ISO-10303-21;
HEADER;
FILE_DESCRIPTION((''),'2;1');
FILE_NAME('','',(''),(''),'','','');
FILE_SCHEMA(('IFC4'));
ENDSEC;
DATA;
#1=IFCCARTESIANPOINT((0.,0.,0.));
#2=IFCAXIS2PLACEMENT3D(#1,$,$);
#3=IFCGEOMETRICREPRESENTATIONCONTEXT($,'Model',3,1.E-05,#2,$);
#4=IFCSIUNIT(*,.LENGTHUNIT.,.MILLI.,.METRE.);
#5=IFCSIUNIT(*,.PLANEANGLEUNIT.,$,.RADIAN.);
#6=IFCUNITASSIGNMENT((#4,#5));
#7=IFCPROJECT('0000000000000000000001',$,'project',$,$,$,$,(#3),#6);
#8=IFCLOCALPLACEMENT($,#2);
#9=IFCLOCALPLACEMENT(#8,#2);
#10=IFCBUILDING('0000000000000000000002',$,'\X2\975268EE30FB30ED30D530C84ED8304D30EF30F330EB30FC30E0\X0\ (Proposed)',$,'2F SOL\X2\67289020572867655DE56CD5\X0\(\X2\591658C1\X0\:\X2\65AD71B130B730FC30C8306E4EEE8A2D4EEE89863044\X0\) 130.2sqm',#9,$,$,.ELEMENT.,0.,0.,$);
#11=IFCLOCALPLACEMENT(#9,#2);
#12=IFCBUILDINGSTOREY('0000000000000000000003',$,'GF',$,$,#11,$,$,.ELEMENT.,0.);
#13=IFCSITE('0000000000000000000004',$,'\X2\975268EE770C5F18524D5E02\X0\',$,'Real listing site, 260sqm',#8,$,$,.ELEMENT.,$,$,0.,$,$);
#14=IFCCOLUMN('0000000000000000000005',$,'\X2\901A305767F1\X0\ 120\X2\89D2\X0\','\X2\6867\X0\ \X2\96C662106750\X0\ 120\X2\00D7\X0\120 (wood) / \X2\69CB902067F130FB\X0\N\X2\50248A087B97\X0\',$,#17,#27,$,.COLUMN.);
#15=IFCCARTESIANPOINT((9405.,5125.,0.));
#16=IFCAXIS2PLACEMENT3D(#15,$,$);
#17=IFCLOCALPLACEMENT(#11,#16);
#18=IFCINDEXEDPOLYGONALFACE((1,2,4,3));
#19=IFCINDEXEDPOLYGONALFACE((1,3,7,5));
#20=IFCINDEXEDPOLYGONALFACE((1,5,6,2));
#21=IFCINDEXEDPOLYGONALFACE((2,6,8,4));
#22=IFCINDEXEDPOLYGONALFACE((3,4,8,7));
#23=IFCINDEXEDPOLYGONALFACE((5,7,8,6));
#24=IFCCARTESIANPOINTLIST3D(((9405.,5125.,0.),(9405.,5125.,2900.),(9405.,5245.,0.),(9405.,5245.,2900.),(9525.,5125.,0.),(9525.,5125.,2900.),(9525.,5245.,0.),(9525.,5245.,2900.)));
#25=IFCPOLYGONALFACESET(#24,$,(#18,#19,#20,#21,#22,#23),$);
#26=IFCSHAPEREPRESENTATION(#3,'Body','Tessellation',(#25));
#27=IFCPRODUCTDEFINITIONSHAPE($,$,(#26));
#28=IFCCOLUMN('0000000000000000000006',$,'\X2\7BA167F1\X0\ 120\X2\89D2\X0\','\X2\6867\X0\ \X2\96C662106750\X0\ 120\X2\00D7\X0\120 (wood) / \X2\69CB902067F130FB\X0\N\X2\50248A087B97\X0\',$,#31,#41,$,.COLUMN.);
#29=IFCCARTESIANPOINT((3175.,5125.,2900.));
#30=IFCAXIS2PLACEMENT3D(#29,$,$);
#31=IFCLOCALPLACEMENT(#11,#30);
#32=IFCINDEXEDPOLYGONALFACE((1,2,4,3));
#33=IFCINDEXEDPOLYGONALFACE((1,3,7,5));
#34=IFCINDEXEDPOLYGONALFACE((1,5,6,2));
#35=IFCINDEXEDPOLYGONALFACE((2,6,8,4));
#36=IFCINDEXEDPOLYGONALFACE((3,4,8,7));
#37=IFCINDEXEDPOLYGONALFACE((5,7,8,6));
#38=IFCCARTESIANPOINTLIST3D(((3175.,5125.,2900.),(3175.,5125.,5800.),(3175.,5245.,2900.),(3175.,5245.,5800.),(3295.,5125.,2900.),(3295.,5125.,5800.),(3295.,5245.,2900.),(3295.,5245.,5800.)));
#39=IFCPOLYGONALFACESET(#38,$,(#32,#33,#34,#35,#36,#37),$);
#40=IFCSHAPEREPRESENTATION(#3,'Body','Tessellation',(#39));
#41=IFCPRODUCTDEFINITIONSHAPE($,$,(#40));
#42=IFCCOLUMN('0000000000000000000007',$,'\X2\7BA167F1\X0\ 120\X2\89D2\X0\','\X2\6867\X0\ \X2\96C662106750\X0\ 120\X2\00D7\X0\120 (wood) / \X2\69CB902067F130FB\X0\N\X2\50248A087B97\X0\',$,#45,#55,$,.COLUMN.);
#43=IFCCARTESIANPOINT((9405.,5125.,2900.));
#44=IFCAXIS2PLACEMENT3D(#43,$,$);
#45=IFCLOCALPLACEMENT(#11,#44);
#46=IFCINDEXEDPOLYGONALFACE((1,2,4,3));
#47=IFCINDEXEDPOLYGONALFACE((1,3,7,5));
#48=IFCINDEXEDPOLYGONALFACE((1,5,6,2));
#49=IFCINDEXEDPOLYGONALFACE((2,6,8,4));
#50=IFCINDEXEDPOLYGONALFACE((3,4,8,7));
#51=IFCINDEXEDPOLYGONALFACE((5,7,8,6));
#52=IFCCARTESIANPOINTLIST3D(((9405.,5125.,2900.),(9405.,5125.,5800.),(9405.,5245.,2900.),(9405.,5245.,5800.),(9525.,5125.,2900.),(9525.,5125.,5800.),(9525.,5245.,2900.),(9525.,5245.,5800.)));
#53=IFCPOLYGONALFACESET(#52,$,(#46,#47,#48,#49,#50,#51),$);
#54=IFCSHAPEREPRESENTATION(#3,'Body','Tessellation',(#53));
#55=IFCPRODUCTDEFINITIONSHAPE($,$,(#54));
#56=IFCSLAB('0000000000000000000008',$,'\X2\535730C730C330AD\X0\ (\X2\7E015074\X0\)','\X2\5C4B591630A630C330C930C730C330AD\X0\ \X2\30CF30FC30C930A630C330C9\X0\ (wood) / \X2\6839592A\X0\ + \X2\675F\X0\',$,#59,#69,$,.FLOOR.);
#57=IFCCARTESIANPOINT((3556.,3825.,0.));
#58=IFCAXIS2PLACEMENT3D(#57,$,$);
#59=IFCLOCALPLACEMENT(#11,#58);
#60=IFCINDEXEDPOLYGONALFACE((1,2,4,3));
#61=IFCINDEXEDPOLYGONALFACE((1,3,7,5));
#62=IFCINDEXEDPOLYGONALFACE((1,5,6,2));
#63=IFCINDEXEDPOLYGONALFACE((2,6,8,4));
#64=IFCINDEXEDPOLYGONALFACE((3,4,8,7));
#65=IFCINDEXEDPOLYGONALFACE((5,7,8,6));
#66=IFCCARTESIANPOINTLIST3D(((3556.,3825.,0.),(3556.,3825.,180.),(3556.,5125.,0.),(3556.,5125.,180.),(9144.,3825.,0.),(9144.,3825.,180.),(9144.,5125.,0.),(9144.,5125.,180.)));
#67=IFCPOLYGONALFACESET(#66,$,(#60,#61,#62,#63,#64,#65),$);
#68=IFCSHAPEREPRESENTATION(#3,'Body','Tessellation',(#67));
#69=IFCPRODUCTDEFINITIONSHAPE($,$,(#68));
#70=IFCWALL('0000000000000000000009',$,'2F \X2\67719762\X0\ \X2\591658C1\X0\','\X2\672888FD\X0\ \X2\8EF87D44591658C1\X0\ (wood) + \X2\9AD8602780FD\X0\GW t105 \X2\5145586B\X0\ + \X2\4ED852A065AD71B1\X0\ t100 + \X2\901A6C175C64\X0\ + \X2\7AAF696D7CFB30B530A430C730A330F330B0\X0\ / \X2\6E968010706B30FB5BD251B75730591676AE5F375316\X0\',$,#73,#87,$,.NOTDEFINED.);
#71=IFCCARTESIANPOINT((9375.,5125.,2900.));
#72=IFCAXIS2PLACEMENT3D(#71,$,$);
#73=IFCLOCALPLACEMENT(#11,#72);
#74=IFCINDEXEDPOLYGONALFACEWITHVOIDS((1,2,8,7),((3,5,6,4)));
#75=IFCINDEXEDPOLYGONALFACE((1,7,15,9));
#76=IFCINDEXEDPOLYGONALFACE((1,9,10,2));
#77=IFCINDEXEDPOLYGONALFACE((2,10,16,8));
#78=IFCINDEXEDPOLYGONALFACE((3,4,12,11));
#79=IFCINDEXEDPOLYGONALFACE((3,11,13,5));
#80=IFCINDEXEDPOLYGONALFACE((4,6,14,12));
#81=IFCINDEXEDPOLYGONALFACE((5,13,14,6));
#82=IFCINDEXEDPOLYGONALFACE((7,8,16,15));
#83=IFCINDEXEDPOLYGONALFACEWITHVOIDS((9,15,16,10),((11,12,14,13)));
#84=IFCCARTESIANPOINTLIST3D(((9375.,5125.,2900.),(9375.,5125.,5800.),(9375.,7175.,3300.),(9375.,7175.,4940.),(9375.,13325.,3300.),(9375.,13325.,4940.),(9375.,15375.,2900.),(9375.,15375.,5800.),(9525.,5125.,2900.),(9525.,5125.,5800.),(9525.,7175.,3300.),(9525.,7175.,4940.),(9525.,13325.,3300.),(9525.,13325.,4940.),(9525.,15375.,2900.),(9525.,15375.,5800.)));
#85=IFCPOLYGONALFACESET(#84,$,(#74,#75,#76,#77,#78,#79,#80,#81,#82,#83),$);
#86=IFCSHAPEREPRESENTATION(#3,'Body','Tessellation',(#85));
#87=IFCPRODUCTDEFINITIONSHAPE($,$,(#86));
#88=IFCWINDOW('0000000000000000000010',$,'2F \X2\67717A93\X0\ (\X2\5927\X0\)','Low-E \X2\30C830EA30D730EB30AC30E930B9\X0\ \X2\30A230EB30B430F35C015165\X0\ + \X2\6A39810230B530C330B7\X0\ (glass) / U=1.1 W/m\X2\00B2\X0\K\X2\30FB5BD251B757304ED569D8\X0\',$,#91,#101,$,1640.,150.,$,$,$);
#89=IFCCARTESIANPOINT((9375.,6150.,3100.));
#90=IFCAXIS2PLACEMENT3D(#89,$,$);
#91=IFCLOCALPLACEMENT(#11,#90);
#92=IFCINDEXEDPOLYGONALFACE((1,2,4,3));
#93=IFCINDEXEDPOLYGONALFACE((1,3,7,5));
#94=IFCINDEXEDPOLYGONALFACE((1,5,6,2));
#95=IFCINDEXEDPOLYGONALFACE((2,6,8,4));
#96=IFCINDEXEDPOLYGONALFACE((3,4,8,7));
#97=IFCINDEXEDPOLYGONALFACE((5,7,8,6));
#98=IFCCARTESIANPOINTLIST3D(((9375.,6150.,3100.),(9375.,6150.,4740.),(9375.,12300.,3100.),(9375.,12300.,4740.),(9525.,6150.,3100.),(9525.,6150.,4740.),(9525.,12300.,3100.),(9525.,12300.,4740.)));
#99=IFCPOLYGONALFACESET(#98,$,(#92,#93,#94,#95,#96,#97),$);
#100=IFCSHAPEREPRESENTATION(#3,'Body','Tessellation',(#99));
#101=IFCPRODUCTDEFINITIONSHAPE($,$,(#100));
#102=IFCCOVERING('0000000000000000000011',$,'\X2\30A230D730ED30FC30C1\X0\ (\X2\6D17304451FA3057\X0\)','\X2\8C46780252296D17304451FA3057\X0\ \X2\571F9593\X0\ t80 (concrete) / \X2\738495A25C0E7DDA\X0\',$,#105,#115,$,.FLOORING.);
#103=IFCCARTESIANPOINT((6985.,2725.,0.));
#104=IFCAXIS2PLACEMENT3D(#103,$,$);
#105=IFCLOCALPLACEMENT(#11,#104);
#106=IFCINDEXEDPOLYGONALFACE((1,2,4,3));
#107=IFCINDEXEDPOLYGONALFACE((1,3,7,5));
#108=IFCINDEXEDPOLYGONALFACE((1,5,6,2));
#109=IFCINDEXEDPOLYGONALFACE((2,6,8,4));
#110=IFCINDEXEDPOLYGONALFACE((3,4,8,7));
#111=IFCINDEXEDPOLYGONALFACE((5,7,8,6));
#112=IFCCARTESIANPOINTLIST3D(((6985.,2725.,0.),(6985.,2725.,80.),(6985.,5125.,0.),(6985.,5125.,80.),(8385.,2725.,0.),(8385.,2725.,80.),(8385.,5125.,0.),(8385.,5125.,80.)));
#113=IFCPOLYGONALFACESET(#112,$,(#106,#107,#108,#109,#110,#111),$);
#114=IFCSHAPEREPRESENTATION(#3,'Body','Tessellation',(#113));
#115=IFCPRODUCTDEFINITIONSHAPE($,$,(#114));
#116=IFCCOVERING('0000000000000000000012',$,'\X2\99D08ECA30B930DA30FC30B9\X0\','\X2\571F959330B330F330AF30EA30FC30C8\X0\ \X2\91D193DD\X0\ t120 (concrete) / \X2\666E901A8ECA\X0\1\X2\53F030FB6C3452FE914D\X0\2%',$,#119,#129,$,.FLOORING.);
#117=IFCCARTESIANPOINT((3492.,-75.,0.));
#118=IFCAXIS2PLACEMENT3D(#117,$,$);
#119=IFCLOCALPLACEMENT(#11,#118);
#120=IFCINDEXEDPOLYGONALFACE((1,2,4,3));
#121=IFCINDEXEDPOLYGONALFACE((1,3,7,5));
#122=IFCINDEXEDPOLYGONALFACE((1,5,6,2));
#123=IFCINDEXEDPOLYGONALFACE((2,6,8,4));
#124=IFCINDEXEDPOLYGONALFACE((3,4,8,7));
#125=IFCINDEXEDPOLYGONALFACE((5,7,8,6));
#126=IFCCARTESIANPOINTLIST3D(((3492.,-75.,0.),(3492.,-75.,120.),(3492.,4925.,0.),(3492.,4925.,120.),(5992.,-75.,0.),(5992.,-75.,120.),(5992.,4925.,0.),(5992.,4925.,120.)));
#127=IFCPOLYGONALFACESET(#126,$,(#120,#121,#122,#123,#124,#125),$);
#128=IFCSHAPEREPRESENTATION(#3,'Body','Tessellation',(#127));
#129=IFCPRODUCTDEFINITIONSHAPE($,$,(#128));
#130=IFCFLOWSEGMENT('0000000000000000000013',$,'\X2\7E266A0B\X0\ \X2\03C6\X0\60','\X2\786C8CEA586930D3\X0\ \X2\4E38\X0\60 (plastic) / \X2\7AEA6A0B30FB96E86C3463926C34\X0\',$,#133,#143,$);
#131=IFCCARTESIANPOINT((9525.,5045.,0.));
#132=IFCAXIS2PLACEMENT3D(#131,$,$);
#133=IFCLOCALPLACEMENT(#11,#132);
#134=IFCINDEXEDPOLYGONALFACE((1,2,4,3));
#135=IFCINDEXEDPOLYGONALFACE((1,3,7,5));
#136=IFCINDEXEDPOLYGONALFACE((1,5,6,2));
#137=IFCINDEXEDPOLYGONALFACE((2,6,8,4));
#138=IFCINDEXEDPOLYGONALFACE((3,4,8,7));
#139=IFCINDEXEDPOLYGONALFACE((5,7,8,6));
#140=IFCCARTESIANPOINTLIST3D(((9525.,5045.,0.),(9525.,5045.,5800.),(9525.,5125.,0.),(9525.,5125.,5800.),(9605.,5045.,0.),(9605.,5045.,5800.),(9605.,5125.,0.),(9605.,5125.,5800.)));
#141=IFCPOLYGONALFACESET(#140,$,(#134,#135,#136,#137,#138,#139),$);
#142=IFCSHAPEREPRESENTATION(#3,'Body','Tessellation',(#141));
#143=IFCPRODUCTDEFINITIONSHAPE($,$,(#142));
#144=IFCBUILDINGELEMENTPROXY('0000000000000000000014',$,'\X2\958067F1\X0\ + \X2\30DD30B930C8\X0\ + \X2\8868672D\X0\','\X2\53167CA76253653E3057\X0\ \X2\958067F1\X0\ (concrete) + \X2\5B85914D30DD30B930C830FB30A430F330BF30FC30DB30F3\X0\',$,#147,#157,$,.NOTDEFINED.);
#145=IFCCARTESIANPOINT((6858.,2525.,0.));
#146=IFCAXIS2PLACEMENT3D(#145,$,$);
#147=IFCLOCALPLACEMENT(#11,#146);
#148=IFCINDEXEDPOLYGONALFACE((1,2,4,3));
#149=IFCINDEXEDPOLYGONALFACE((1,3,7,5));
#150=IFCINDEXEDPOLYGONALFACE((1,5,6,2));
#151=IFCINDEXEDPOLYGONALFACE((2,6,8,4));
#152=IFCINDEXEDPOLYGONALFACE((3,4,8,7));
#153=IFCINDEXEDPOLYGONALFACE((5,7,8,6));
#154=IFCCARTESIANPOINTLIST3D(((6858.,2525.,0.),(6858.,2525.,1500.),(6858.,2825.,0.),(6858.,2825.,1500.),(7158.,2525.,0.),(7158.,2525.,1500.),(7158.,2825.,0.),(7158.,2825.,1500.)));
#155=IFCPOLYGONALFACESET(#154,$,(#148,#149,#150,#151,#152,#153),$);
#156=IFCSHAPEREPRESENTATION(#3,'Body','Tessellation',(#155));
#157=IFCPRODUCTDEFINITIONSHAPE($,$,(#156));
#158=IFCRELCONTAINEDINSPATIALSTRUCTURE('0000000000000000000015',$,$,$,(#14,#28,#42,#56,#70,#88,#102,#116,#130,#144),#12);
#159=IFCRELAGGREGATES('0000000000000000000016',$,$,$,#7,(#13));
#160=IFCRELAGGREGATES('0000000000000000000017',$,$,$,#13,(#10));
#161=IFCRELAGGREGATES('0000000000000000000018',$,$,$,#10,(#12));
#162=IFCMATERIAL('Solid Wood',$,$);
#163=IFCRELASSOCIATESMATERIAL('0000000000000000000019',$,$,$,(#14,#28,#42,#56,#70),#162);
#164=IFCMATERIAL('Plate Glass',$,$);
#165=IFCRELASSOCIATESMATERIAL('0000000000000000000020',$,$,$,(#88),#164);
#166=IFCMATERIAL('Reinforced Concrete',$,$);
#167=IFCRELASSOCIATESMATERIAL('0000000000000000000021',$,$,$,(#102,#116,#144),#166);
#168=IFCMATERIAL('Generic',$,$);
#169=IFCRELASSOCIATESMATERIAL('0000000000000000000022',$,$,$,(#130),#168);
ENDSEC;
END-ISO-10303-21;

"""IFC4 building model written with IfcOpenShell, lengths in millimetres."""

from ifc_helpers import new_model, si_unit, frame, frame_2d, origin, place, context, project, spatial, rectangle, extrude, material, element, fill, save


model = new_model("IFC4")

# Units and contexts
model_context = context("Model", 3, precision=1e-05, world=origin())
ifc_project = project(units=[si_unit("LENGTHUNIT", "METRE", prefix="MILLI"), si_unit("PLANEANGLEUNIT", "RADIAN")], contexts=[model_context])

# Site, building, storey
site_placement = place(None, origin())
site = spatial("IfcSite", under=ifc_project, at=site_placement, Name="青森県弘前市", ObjectType="Real listing site, 260sqm", CompositionType="ELEMENT", RefElevation=0.0)
building_placement = place(site_placement, origin())
building = spatial("IfcBuilding", under=site, at=building_placement, Name="青森・ロフト付きワンルーム (Proposed)", ObjectType="2F SOL木造在来工法(外壁:断熱シートの仮設仮覆い) 130.2sqm", CompositionType="ELEMENT", ElevationOfRefHeight=0.0, ElevationOfTerrain=0.0)
storey_placement = place(building_placement, origin())
storey = spatial("IfcBuildingStorey", under=building, at=storey_placement, Name="GF", CompositionType="ELEMENT", Elevation=0.0)

# Columns
ifc_material_1 = material(Name="Solid Wood")
column_1_placement = place(storey_placement, frame((9405.0, 5125.0, 0.0)))
element("IfcColumn", 1, at=column_1_placement, inside=storey, material=ifc_material_1, Name="通し柱 120角", Description="桧 集成材 120×120 (wood) / 構造柱・N値計算", PredefinedType="COLUMN", context=model_context, shape_type="SweptSolid", body=[
    extrude(rectangle(XDim=120.0, YDim=120.0, at=frame_2d((60.0, 60.0))), frame((9405.0, 5125.0, 0.0)), (0.0, 0.0, 1.0), 2900.0),
])
column_2_placement = place(storey_placement, frame((3175.0, 5125.0, 2900.0)))
element("IfcColumn", 2, at=column_2_placement, inside=storey, material=ifc_material_1, Name="管柱 120角", Description="桧 集成材 120×120 (wood) / 構造柱・N値計算", PredefinedType="COLUMN", context=model_context, shape_type="SweptSolid", body=[
    extrude(rectangle(XDim=120.0, YDim=120.0, at=frame_2d((60.0, 60.0))), frame((3175.0, 5125.0, 2900.0)), (0.0, 0.0, 1.0), 2900.0),
])
column_3_placement = place(storey_placement, frame((9405.0, 5125.0, 2900.0)))
element("IfcColumn", 3, at=column_3_placement, inside=storey, material=ifc_material_1, Name="管柱 120角", Description="桧 集成材 120×120 (wood) / 構造柱・N値計算", PredefinedType="COLUMN", context=model_context, shape_type="SweptSolid", body=[
    extrude(rectangle(XDim=120.0, YDim=120.0, at=frame_2d((60.0, 60.0))), frame((9405.0, 5125.0, 2900.0)), (0.0, 0.0, 1.0), 2900.0),
])

# Slab
slab_placement = place(storey_placement, frame((3556.0, 3825.0, 0.0)))
element("IfcSlab", 4, at=slab_placement, inside=storey, material=ifc_material_1, Name="南デッキ (縁側)", Description="屋外ウッドデッキ ハードウッド (wood) / 根太 + 束", PredefinedType="FLOOR", context=model_context, shape_type="SweptSolid", body=[
    extrude(rectangle(XDim=5588.0, YDim=1300.0, at=frame_2d((2794.0, 650.0))), frame((3556.0, 3825.0, 0.0)), (0.0, 0.0, 1.0), 180.0),
])

# Wall, opening, window
ifc_material_2 = material(Name="Plate Glass")
wall_1_placement = place(storey_placement, frame((9375.0, 5125.0, 2900.0)))
wall_1 = element("IfcWall", 5, at=wall_1_placement, inside=storey, material=ifc_material_1, Name="2F 東面 外壁", Description="木製 軸組外壁 (wood) + 高性能GW t105 充填 + 付加断熱 t100 + 通気層 + 窯業系サイディング / 準耐火・寒冷地外皮強化", PredefinedType="NOTDEFINED", context=model_context, shape_type="SweptSolid", body=[
    extrude(rectangle(XDim=150.0, YDim=10250.0, at=frame_2d((75.0, 5125.0))), frame((9375.0, 5125.0, 2900.0)), (0.0, 0.0, 1.0), 2900.0),
])
opening_1_placement = place(storey_placement, frame((9375.0, 6150.0, 3100.0)))
opening_1 = element("IfcOpeningElement", 6, at=opening_1_placement, cuts=wall_1, PredefinedType="NOTDEFINED", context=model_context, shape_type="SweptSolid", body=[
    extrude(rectangle(XDim=150.0, YDim=6150.0, at=frame_2d((75.0, 3075.0))), frame((9375.0, 6150.0, 3100.0)), (0.0, 0.0, 1.0), 1640.0),
])
window_1_placement = place(storey_placement, frame((9375.0, 6150.0, 3100.0)))
window_1 = element("IfcWindow", 7, at=window_1_placement, inside=storey, material=ifc_material_2, Name="2F 東窓 (大)", Description="Low-E トリプルガラス アルゴン封入 + 樹脂サッシ (glass) / U=1.1 W/m²K・寒冷地仕様", OverallHeight=1640.0, OverallWidth=150.0, context=model_context, shape_type="SweptSolid", body=[
    extrude(rectangle(XDim=150.0, YDim=6150.0, at=frame_2d((75.0, 3075.0))), frame((9375.0, 6150.0, 3100.0)), (0.0, 0.0, 1.0), 1640.0),
])
fill(opening_1, window_1)

# Coverings
ifc_material_3 = material(Name="Reinforced Concrete")
covering_1_placement = place(storey_placement, frame((6985.0, 2725.0, 0.0)))
element("IfcCovering", 8, at=covering_1_placement, inside=storey, material=ifc_material_3, Name="アプローチ (洗い出し)", Description="豆砂利洗い出し 土間 t80 (concrete) / 玄関導線", PredefinedType="FLOORING", context=model_context, shape_type="SweptSolid", body=[
    extrude(rectangle(XDim=1400.0, YDim=2400.0, at=frame_2d((700.0, 1200.0))), frame((6985.0, 2725.0, 0.0)), (0.0, 0.0, 1.0), 80.0),
])
covering_2_placement = place(storey_placement, frame((3492.0, -75.0, 0.0)))
element("IfcCovering", 9, at=covering_2_placement, inside=storey, material=ifc_material_3, Name="駐車スペース", Description="土間コンクリート 金鏝 t120 (concrete) / 普通車1台・水勾配2%", PredefinedType="FLOORING", context=model_context, shape_type="SweptSolid", body=[
    extrude(rectangle(XDim=2500.0, YDim=5000.0, at=frame_2d((1250.0, 2500.0))), frame((3492.0, -75.0, 0.0)), (0.0, 0.0, 1.0), 120.0),
])

# Flow segment
ifc_material_4 = material(Name="Generic")
flow_segment_placement = place(storey_placement, frame((9525.0, 5045.0, 0.0)))
element("IfcFlowSegment", 10, at=flow_segment_placement, inside=storey, material=ifc_material_4, Name="縦樋 φ60", Description="硬質塩ビ 丸60 (plastic) / 竪樋・雨水排水", context=model_context, shape_type="SweptSolid", body=[
    extrude(rectangle(XDim=80.0, YDim=80.0, at=frame_2d((40.0, 40.0))), frame((9525.0, 5045.0, 0.0)), (0.0, 0.0, 1.0), 5800.0),
])

# Building element proxy
proxy_placement = place(storey_placement, frame((6858.0, 2525.0, 0.0)))
element("IfcBuildingElementProxy", 11, at=proxy_placement, inside=storey, material=ifc_material_3, Name="門柱 + ポスト + 表札", Description="化粧打放し 門柱 (concrete) + 宅配ポスト・インターホン", PredefinedType="NOTDEFINED", context=model_context, shape_type="SweptSolid", body=[
    extrude(rectangle(XDim=300.0, YDim=300.0, at=frame_2d((150.0, 150.0))), frame((6858.0, 2525.0, 0.0)), (0.0, 0.0, 1.0), 1500.0),
])

save(model, "model.ifc")
